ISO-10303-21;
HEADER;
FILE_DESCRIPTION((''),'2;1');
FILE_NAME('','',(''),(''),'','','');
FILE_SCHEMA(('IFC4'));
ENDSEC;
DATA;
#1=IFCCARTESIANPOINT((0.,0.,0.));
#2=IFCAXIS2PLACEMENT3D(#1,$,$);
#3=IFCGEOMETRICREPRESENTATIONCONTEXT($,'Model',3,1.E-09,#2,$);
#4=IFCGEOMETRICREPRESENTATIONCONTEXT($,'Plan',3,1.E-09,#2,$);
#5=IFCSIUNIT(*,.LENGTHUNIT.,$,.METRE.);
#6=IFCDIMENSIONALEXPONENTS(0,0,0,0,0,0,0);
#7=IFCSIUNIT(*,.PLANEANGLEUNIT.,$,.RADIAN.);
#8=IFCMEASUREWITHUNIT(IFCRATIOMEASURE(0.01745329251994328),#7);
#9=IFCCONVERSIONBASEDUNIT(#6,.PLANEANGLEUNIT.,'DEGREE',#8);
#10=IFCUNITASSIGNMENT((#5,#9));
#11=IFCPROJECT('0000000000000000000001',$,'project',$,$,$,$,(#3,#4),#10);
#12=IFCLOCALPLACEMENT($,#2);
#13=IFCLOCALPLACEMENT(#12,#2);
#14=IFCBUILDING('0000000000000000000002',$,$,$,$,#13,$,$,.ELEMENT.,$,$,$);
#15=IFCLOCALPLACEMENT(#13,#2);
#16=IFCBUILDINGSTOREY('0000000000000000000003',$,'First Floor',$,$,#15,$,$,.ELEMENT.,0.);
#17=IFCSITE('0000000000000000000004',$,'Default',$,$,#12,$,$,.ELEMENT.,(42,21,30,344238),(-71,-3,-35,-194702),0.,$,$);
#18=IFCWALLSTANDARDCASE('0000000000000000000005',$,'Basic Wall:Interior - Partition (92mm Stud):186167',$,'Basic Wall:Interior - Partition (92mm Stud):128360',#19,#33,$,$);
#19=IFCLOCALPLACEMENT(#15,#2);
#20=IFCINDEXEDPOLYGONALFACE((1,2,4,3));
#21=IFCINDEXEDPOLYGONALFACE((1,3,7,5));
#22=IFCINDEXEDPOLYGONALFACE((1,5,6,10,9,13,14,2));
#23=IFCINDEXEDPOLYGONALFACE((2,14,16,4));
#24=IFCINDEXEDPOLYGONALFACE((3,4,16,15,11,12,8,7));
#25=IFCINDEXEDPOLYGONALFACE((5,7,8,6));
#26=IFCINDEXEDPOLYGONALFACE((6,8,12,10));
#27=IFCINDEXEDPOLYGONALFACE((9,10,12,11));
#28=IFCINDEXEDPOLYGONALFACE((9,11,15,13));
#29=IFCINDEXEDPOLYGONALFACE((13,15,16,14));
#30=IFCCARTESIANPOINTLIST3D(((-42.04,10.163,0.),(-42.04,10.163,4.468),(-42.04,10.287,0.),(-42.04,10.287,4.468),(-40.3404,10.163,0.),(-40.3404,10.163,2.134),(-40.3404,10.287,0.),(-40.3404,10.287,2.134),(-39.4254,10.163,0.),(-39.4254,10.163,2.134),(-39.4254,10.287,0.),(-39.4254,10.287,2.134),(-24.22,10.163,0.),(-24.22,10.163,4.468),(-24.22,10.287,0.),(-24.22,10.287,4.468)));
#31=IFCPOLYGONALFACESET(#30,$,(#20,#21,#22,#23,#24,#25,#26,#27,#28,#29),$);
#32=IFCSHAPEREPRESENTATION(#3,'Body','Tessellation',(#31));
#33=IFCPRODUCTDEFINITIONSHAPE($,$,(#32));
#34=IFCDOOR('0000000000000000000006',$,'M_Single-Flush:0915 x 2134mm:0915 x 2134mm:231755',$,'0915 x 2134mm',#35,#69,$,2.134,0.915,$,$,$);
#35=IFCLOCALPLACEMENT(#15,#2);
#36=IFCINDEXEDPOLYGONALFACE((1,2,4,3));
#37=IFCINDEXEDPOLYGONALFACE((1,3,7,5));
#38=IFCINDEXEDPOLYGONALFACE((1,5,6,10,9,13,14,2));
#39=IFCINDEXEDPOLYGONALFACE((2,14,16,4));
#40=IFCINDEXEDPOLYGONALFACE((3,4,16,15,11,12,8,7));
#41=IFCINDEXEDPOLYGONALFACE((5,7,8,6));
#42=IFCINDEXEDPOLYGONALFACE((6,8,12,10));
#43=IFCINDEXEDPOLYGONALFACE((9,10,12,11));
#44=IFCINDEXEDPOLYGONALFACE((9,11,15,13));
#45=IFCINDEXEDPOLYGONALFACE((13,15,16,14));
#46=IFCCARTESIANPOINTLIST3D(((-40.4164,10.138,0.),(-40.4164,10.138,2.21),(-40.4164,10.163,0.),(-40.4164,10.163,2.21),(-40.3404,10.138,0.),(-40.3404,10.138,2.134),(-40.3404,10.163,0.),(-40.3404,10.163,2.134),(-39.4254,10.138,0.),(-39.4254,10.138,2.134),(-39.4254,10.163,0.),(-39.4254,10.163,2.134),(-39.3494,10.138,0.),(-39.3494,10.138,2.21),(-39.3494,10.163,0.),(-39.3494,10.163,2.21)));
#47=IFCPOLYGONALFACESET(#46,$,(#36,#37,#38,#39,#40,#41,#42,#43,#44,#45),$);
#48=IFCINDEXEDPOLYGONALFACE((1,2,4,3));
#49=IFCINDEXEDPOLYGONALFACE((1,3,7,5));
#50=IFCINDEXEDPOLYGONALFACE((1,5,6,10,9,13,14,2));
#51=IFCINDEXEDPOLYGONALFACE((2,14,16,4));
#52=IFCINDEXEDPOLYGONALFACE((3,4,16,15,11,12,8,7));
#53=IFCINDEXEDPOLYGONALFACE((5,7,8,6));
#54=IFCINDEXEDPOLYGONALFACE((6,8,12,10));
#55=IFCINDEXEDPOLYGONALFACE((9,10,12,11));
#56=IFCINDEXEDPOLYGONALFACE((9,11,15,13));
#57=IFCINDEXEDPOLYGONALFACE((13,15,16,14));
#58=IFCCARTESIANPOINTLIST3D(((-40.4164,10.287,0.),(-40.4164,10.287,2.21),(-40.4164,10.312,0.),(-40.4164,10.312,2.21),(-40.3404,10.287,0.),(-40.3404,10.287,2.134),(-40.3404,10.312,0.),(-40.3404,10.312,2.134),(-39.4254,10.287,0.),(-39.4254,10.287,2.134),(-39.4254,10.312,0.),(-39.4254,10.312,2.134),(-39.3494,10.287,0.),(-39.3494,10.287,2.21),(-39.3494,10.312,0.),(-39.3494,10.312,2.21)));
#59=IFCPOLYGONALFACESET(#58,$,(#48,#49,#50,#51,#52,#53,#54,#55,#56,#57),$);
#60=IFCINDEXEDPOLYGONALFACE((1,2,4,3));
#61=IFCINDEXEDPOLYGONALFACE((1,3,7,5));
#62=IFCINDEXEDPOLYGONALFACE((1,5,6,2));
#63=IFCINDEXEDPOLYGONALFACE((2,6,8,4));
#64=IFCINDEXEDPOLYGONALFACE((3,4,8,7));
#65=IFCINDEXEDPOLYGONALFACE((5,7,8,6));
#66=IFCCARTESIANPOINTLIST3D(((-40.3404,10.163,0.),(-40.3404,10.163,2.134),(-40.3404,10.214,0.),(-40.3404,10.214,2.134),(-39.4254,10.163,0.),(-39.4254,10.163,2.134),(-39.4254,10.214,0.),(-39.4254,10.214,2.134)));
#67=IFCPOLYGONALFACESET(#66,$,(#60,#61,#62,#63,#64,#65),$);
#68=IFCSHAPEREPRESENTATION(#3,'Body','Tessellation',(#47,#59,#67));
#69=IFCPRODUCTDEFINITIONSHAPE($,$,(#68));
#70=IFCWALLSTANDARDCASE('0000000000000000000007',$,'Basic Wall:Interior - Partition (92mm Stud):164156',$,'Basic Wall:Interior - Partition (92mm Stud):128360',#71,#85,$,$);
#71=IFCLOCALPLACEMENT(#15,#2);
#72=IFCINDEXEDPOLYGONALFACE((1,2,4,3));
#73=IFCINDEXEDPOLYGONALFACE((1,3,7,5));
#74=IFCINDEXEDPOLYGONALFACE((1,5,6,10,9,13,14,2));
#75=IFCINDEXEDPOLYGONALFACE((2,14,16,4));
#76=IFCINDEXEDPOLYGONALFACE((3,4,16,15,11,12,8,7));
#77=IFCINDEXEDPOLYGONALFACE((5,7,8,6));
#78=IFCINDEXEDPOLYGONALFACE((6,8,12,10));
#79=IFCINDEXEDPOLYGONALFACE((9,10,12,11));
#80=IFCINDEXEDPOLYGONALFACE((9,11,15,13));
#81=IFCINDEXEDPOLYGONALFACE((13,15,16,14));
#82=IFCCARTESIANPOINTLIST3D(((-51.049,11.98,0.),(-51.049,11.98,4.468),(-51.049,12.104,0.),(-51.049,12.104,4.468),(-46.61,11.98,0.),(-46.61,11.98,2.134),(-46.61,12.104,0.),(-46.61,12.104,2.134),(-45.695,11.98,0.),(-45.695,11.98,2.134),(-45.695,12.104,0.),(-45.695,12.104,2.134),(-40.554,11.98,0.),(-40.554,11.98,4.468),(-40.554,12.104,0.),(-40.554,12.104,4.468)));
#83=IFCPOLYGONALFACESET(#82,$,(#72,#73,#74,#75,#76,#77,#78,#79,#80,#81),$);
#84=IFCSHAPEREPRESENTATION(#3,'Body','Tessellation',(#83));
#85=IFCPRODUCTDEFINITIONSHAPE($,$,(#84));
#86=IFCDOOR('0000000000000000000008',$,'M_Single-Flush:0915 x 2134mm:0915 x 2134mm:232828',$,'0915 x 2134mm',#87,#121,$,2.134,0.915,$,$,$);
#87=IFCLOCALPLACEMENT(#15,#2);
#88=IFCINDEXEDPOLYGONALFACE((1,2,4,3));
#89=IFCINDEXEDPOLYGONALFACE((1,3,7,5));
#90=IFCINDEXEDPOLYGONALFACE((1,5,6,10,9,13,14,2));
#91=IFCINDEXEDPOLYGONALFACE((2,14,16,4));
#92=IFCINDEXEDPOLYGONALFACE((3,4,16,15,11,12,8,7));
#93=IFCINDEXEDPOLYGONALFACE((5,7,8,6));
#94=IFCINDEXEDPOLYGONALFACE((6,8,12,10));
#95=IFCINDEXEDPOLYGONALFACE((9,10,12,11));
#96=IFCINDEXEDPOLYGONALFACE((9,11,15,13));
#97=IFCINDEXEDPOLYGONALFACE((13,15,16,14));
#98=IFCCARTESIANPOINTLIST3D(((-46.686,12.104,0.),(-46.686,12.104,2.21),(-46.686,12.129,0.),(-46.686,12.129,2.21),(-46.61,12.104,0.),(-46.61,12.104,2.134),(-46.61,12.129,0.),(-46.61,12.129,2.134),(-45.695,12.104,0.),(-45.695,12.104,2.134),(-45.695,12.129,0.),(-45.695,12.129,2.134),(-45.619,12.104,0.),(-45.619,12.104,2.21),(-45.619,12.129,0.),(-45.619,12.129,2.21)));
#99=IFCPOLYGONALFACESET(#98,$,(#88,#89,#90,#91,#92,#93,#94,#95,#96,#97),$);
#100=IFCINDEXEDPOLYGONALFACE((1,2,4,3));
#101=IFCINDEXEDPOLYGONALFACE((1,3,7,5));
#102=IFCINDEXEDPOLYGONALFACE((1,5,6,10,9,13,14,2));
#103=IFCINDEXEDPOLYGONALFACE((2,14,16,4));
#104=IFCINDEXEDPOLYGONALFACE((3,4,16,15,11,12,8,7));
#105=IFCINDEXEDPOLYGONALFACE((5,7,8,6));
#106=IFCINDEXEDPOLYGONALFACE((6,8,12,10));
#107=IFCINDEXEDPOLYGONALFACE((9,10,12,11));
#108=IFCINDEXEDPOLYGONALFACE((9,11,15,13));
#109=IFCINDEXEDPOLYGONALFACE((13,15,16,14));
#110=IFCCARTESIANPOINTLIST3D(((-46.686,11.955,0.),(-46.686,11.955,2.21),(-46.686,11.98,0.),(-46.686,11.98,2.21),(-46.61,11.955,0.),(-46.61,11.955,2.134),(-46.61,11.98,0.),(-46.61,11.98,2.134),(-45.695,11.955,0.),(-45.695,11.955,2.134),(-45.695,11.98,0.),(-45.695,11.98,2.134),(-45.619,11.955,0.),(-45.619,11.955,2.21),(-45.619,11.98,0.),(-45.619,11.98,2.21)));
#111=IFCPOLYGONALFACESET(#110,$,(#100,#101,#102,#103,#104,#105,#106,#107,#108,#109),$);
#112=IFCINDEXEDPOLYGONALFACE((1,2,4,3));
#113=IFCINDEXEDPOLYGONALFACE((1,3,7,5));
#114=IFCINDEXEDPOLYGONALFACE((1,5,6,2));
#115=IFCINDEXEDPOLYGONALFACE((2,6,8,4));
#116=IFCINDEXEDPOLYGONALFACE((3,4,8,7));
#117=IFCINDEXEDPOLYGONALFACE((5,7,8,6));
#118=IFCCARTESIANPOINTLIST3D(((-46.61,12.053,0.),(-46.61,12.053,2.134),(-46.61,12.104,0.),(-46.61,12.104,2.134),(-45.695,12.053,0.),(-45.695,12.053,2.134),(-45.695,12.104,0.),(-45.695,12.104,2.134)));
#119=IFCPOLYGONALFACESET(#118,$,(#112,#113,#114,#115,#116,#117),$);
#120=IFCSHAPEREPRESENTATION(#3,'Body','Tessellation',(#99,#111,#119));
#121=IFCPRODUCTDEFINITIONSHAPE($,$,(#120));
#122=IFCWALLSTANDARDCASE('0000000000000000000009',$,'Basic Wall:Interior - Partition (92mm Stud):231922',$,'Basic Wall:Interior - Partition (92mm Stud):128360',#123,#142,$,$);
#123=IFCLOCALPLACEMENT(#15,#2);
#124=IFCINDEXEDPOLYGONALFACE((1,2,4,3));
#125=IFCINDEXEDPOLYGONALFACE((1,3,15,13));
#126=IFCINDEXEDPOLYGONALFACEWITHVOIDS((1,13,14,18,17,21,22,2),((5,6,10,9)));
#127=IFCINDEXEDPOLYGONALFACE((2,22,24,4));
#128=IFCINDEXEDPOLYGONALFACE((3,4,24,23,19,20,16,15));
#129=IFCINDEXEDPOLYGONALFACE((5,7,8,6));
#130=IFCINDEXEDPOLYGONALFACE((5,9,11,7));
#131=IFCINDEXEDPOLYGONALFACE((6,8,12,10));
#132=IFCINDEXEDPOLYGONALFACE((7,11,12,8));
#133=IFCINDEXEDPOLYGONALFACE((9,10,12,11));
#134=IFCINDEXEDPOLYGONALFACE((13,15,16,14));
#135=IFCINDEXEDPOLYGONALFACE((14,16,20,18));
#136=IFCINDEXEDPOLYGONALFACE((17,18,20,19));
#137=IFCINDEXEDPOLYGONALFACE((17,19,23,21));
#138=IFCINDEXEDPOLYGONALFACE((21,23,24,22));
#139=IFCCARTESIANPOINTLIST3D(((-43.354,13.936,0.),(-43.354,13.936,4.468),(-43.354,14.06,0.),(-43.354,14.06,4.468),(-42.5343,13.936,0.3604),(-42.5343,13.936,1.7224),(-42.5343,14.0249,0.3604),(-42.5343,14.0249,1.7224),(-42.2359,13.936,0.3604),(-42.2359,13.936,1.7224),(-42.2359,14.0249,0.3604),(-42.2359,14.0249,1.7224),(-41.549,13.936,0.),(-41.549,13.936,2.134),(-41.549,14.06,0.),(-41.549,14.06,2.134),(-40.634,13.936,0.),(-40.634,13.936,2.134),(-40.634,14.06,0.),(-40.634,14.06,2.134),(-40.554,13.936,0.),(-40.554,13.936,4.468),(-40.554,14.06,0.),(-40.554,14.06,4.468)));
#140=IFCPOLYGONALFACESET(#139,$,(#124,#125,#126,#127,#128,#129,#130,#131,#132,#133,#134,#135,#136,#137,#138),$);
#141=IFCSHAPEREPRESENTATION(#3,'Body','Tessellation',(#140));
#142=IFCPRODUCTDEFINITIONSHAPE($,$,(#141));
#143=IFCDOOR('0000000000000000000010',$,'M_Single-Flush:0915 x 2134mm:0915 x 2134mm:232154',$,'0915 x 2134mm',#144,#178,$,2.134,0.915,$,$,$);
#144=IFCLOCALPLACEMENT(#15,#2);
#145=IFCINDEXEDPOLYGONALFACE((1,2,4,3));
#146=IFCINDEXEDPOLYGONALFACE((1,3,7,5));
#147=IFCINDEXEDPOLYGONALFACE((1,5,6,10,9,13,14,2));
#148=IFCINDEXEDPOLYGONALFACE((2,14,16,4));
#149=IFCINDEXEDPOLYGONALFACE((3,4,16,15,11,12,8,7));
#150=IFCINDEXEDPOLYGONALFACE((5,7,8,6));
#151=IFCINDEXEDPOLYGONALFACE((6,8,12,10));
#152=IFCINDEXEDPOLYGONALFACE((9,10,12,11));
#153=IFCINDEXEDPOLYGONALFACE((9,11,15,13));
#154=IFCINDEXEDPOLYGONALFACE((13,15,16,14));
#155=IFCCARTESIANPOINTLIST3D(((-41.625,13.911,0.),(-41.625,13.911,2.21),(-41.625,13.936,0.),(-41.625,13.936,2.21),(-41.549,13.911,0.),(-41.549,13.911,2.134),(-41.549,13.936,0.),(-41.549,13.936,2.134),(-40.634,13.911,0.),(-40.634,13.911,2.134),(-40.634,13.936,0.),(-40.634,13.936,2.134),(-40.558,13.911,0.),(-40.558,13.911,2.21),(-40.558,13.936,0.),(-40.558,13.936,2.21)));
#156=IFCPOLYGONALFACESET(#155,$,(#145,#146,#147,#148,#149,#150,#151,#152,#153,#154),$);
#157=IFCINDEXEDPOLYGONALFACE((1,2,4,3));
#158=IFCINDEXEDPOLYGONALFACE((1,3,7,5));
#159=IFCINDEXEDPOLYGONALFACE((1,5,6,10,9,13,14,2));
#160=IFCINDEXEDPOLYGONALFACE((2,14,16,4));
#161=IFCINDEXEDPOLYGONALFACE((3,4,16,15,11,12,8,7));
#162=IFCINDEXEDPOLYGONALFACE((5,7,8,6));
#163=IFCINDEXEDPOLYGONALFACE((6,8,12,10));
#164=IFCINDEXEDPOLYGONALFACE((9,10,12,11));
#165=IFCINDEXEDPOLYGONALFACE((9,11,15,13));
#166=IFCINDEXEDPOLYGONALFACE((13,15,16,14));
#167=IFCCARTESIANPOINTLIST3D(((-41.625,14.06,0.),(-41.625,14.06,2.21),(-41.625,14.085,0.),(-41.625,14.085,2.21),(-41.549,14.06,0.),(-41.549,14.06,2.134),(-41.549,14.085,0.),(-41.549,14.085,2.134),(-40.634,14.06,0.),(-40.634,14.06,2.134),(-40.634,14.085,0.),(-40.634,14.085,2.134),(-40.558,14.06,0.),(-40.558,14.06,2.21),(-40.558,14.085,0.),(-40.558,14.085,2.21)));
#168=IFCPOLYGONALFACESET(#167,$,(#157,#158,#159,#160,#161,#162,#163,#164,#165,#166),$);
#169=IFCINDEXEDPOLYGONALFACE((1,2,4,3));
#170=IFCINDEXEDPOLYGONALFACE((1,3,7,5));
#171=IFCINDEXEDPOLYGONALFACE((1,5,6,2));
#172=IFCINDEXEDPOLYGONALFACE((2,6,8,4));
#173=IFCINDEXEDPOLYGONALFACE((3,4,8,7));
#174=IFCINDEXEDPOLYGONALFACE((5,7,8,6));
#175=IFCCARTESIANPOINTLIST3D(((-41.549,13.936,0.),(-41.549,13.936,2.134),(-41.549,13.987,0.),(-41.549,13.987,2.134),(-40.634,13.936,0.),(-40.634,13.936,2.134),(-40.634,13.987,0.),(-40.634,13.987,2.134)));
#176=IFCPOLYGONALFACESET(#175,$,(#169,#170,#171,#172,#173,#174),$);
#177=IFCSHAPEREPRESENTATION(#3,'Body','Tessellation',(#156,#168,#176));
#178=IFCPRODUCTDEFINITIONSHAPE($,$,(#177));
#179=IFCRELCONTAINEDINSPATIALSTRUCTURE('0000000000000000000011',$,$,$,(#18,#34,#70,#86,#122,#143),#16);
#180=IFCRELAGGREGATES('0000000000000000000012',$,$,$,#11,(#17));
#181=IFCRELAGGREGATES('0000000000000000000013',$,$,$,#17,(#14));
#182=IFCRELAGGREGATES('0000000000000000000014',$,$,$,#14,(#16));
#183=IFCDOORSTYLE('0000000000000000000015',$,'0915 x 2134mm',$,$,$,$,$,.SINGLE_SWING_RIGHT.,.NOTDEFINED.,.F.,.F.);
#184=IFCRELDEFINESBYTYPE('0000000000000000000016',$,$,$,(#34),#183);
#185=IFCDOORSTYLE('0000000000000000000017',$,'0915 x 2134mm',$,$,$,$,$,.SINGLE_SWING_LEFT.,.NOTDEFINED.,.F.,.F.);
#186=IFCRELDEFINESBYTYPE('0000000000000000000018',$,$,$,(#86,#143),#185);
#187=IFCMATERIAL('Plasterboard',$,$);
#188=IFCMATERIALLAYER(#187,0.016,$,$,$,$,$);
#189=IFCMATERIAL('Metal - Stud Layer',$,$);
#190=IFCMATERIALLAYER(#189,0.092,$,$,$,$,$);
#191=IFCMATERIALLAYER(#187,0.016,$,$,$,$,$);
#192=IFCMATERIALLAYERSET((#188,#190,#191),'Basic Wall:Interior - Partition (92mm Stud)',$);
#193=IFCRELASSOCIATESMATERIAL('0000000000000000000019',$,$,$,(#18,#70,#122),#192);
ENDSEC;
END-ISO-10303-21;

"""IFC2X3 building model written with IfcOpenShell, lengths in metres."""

from ifc_helpers import new_model, entity, si_unit, converted_unit, frame, frame_2d, origin, origin_2d_with_axis, place, context, project, spatial, polyline, rectangle, outline, extrude, source, transform, mapped, material, layer, layer_set, layer_usage, type_object, type_shapes, element, fill, save


model = new_model("IFC2X3")

# Units and contexts
model_context = context("Model", 3, precision=1e-09, world=origin())
plan_context = context("Plan", 3, precision=1e-09, world=origin())
ifc_project = project(units=[si_unit("LENGTHUNIT", "METRE"), converted_unit("PLANEANGLEUNIT", "DEGREE", entity("IfcRatioMeasure", 0.01745329251994328), si_unit("PLANEANGLEUNIT", "RADIAN"), dimensions=[0, 0, 0, 0, 0, 0, 0])], contexts=[model_context, plan_context])

# Site, building, storey
site_placement = place(None, origin())
site = spatial("IfcSite", under=ifc_project, at=site_placement, Name="Default", CompositionType="ELEMENT", RefLatitude=(42, 21, 30, 344238), RefLongitude=(-71, -3, -35, -194702), RefElevation=0.0)
building_placement = place(site_placement, origin())
building = spatial("IfcBuilding", under=site, at=building_placement, CompositionType="ELEMENT")
storey_placement = place(building_placement, origin())
storey = spatial("IfcBuildingStorey", under=building, at=storey_placement, Name="First Floor", CompositionType="ELEMENT", Elevation=0.0)

# Walls, openings, doors
ifc_material_1 = material(Name="Plasterboard")
ifc_layer_1 = layer(ifc_material_1, 0.016)
ifc_material_2 = material(Name="Metal - Stud Layer")
ifc_layer_2 = layer(ifc_material_2, 0.092)
ifc_layer_3 = layer(ifc_material_1, 0.016)
ifc_layer_set_1 = layer_set([ifc_layer_1, ifc_layer_2, ifc_layer_3], Name="Basic Wall:Interior - Partition (92mm Stud)")
ifc_layer_usage_1 = layer_usage(ifc_layer_set_1, "AXIS2", "NEGATIVE", 0.062)
wall_1_placement = place(storey_placement, frame((-42.04, 10.225, 0.0)))
wall_1 = element("IfcWallStandardCase", 1, at=wall_1_placement, inside=storey, material=ifc_layer_usage_1, Name="Basic Wall:Interior - Partition (92mm Stud):186167", ObjectType="Basic Wall:Interior - Partition (92mm Stud):128360", context=model_context, shape_type="SweptSolid", body=[
    extrude(rectangle(XDim=17.82, YDim=0.124, at=frame_2d((8.91, 0.0), x_axis=(-1.0, 0.0))), origin(), (0.0, 0.0, 1.0), 4.468),
])
opening_1_placement = place(wall_1_placement, frame((2.6146, 0.062, 0.0)))
opening_1 = element("IfcOpeningElement", 2, at=opening_1_placement, cuts=wall_1, ObjectType="Opening", context=model_context, shape_type="SweptSolid", body=[
    extrude(rectangle(XDim=0.915, YDim=2.134, at=frame_2d((1.067, 0.4575), x_axis=(0.0, 1.0))), frame((0.0, 0.0, 0.0), z_axis=(0.0, -1.0, 0.0), x_axis=(0.0, 0.0, 1.0)), (0.0, 0.0, 1.0), 0.124),
])
door_style_1 = type_object("IfcDoorStyle", Name="0915 x 2134mm", ConstructionType="NOTDEFINED", OperationType="SINGLE_SWING_RIGHT", ParameterTakesPrecedence=False, Sizeable=False)
shared_shape_1 = source(origin(), model_context, "Body", "SweptSolid", [
    extrude(outline(polyline([(-0.5335, -1.124), (0.5335, -1.124), (0.5335, 1.086), (0.4575, 1.086), (0.4575, -1.048), (-0.4575, -1.048), (-0.4575, 1.086), (-0.5335, 1.086), (-0.5335, -1.124)])), frame((0.4575, 0.124, 1.086), z_axis=(0.0, 1.0, 0.0), x_axis=(1.0, 0.0, 0.0)), (0.0, 0.0, 1.0), 0.025),
    extrude(outline(polyline([(-1.124, -0.5335), (1.086, -0.5335), (1.086, -0.4575), (-1.048, -0.4575), (-1.048, 0.4575), (1.086, 0.4575), (1.086, 0.5335), (-1.124, 0.5335), (-1.124, -0.5335)])), frame((0.4575, -0.025, 1.086), z_axis=(0.0, 1.0, 0.0), x_axis=(0.0, 0.0, -1.0)), (0.0, 0.0, 1.0), 0.025),
    extrude(rectangle(XDim=0.051, YDim=0.915, at=origin_2d_with_axis()), frame((0.4575, 0.0985, 0.0), z_axis=(0.0, 0.0, 1.0), x_axis=(0.0, 1.0, 0.0)), (0.0, 0.0, 1.0), 2.134),
])
type_shapes(door_style_1, [shared_shape_1])
door_1_placement = place(opening_1_placement, frame((0.0, 0.0, 0.0), z_axis=(0.0, 0.0, 1.0), x_axis=(-1.0, 0.0, 0.0)))
door_1 = element("IfcDoor", 3, at=door_1_placement, inside=storey, type_object=door_style_1, Name="M_Single-Flush:0915 x 2134mm:0915 x 2134mm:231755", ObjectType="0915 x 2134mm", OverallHeight=2.134, OverallWidth=0.915, context=model_context, shape_type="MappedRepresentation", body=[
    mapped(shared_shape_1, transform((0.0, 0.0, 0.0), scale=1.0)),
])
fill(opening_1, door_1)
wall_2_placement = place(storey_placement, frame((-40.554, 12.042, 0.0), z_axis=(0.0, 0.0, 1.0), x_axis=(-1.0, 0.0, 0.0)))
wall_2 = element("IfcWallStandardCase", 4, at=wall_2_placement, inside=storey, material=ifc_layer_usage_1, Name="Basic Wall:Interior - Partition (92mm Stud):164156", ObjectType="Basic Wall:Interior - Partition (92mm Stud):128360", context=model_context, shape_type="SweptSolid", body=[
    extrude(rectangle(XDim=10.495, YDim=0.124, at=frame_2d((5.2475, 0.0), x_axis=(-1.0, 0.0))), origin(), (0.0, 0.0, 1.0), 4.468),
])
opening_2_placement = place(wall_2_placement, frame((6.056, 0.062, 0.0)))
opening_2 = element("IfcOpeningElement", 5, at=opening_2_placement, cuts=wall_2, ObjectType="Opening", context=model_context, shape_type="SweptSolid", body=[
    extrude(rectangle(XDim=0.915, YDim=2.134, at=frame_2d((1.067, 0.4575), x_axis=(0.0, -1.0))), frame((0.0, 0.0, 0.0), z_axis=(0.0, -1.0, 0.0), x_axis=(0.0, 0.0, 1.0)), (0.0, 0.0, 1.0), 0.124),
])
door_style_2 = type_object("IfcDoorStyle", Name="0915 x 2134mm", ConstructionType="NOTDEFINED", OperationType="SINGLE_SWING_LEFT", ParameterTakesPrecedence=False, Sizeable=False)
shared_shape_2 = source(origin(), model_context, "Body", "SweptSolid", [
    extrude(outline(polyline([(-0.5335, -1.124), (0.5335, -1.124), (0.5335, 1.086), (0.4575, 1.086), (0.4575, -1.048), (-0.4575, -1.048), (-0.4575, 1.086), (-0.5335, 1.086), (-0.5335, -1.124)])), frame((0.4575, 0.149, 1.086), z_axis=(0.0, -1.0, 0.0), x_axis=(-1.0, 0.0, 0.0)), (0.0, 0.0, 1.0), 0.025),
    extrude(outline(polyline([(-1.124, -0.5335), (1.086, -0.5335), (1.086, -0.4575), (-1.048, -0.4575), (-1.048, 0.4575), (1.086, 0.4575), (1.086, 0.5335), (-1.124, 0.5335), (-1.124, -0.5335)])), frame((0.4575, 0.0, 1.086), z_axis=(0.0, -1.0, 0.0), x_axis=(0.0, 0.0, -1.0)), (0.0, 0.0, 1.0), 0.025),
    extrude(rectangle(XDim=0.915, YDim=0.051, at=origin_2d_with_axis()), frame((0.4575, 0.0985, 0.0)), (0.0, 0.0, 1.0), 2.134),
])
type_shapes(door_style_2, [shared_shape_2])
door_2_placement = place(opening_2_placement, frame((0.0, 0.0, 0.0), z_axis=(0.0, 0.0, 1.0), x_axis=(-1.0, 0.0, 0.0)))
door_2 = element("IfcDoor", 6, at=door_2_placement, inside=storey, type_object=door_style_2, Name="M_Single-Flush:0915 x 2134mm:0915 x 2134mm:232828", ObjectType="0915 x 2134mm", OverallHeight=2.134, OverallWidth=0.915, context=model_context, shape_type="MappedRepresentation", body=[
    mapped(shared_shape_2, transform((0.0, 0.0, 0.0), scale=1.0)),
])
fill(opening_2, door_2)

# Wall, openings, door
wall_3_placement = place(storey_placement, frame((-43.354, 13.998, 0.0)))
wall_3 = element("IfcWallStandardCase", 7, at=wall_3_placement, inside=storey, material=ifc_layer_usage_1, Name="Basic Wall:Interior - Partition (92mm Stud):231922", ObjectType="Basic Wall:Interior - Partition (92mm Stud):128360", context=model_context, shape_type="SweptSolid", body=[
    extrude(rectangle(XDim=2.8, YDim=0.124, at=frame_2d((1.4, 0.0), x_axis=(-1.0, 0.0))), origin(), (0.0, 0.0, 1.0), 4.468),
])
opening_3_placement = place(wall_3_placement, origin())
element("IfcOpeningElement", 8, at=opening_3_placement, cuts=wall_3, ObjectType="Opening", context=model_context, shape_type="SweptSolid", body=[
    extrude(rectangle(XDim=1.3621, YDim=0.2984, at=origin_2d_with_axis()), frame((0.9689, -0.1255, 1.0414), z_axis=(0.0, 1.0, 0.0), x_axis=(0.0, 0.0, -1.0)), (0.0, 0.0, 1.0), 0.1524),
])
opening_4_placement = place(wall_3_placement, frame((2.72, 0.062, 0.0)))
opening_4 = element("IfcOpeningElement", 9, at=opening_4_placement, cuts=wall_3, ObjectType="Opening", context=model_context, shape_type="SweptSolid", body=[
    extrude(rectangle(XDim=0.915, YDim=2.134, at=frame_2d((1.067, 0.4575), x_axis=(0.0, -1.0))), frame((0.0, 0.0, 0.0), z_axis=(0.0, -1.0, 0.0), x_axis=(0.0, 0.0, 1.0)), (0.0, 0.0, 1.0), 0.124),
])
door_3_placement = place(opening_4_placement, frame((0.0, 0.0, 0.0), z_axis=(0.0, 0.0, 1.0), x_axis=(-1.0, 0.0, 0.0)))
door_3 = element("IfcDoor", 10, at=door_3_placement, inside=storey, type_object=door_style_2, Name="M_Single-Flush:0915 x 2134mm:0915 x 2134mm:232154", ObjectType="0915 x 2134mm", OverallHeight=2.134, OverallWidth=0.915, context=model_context, shape_type="MappedRepresentation", body=[
    mapped(shared_shape_2, transform((0.0, 0.0, 0.0), scale=1.0)),
])
fill(opening_4, door_3)

save(model, "model.ifc")
